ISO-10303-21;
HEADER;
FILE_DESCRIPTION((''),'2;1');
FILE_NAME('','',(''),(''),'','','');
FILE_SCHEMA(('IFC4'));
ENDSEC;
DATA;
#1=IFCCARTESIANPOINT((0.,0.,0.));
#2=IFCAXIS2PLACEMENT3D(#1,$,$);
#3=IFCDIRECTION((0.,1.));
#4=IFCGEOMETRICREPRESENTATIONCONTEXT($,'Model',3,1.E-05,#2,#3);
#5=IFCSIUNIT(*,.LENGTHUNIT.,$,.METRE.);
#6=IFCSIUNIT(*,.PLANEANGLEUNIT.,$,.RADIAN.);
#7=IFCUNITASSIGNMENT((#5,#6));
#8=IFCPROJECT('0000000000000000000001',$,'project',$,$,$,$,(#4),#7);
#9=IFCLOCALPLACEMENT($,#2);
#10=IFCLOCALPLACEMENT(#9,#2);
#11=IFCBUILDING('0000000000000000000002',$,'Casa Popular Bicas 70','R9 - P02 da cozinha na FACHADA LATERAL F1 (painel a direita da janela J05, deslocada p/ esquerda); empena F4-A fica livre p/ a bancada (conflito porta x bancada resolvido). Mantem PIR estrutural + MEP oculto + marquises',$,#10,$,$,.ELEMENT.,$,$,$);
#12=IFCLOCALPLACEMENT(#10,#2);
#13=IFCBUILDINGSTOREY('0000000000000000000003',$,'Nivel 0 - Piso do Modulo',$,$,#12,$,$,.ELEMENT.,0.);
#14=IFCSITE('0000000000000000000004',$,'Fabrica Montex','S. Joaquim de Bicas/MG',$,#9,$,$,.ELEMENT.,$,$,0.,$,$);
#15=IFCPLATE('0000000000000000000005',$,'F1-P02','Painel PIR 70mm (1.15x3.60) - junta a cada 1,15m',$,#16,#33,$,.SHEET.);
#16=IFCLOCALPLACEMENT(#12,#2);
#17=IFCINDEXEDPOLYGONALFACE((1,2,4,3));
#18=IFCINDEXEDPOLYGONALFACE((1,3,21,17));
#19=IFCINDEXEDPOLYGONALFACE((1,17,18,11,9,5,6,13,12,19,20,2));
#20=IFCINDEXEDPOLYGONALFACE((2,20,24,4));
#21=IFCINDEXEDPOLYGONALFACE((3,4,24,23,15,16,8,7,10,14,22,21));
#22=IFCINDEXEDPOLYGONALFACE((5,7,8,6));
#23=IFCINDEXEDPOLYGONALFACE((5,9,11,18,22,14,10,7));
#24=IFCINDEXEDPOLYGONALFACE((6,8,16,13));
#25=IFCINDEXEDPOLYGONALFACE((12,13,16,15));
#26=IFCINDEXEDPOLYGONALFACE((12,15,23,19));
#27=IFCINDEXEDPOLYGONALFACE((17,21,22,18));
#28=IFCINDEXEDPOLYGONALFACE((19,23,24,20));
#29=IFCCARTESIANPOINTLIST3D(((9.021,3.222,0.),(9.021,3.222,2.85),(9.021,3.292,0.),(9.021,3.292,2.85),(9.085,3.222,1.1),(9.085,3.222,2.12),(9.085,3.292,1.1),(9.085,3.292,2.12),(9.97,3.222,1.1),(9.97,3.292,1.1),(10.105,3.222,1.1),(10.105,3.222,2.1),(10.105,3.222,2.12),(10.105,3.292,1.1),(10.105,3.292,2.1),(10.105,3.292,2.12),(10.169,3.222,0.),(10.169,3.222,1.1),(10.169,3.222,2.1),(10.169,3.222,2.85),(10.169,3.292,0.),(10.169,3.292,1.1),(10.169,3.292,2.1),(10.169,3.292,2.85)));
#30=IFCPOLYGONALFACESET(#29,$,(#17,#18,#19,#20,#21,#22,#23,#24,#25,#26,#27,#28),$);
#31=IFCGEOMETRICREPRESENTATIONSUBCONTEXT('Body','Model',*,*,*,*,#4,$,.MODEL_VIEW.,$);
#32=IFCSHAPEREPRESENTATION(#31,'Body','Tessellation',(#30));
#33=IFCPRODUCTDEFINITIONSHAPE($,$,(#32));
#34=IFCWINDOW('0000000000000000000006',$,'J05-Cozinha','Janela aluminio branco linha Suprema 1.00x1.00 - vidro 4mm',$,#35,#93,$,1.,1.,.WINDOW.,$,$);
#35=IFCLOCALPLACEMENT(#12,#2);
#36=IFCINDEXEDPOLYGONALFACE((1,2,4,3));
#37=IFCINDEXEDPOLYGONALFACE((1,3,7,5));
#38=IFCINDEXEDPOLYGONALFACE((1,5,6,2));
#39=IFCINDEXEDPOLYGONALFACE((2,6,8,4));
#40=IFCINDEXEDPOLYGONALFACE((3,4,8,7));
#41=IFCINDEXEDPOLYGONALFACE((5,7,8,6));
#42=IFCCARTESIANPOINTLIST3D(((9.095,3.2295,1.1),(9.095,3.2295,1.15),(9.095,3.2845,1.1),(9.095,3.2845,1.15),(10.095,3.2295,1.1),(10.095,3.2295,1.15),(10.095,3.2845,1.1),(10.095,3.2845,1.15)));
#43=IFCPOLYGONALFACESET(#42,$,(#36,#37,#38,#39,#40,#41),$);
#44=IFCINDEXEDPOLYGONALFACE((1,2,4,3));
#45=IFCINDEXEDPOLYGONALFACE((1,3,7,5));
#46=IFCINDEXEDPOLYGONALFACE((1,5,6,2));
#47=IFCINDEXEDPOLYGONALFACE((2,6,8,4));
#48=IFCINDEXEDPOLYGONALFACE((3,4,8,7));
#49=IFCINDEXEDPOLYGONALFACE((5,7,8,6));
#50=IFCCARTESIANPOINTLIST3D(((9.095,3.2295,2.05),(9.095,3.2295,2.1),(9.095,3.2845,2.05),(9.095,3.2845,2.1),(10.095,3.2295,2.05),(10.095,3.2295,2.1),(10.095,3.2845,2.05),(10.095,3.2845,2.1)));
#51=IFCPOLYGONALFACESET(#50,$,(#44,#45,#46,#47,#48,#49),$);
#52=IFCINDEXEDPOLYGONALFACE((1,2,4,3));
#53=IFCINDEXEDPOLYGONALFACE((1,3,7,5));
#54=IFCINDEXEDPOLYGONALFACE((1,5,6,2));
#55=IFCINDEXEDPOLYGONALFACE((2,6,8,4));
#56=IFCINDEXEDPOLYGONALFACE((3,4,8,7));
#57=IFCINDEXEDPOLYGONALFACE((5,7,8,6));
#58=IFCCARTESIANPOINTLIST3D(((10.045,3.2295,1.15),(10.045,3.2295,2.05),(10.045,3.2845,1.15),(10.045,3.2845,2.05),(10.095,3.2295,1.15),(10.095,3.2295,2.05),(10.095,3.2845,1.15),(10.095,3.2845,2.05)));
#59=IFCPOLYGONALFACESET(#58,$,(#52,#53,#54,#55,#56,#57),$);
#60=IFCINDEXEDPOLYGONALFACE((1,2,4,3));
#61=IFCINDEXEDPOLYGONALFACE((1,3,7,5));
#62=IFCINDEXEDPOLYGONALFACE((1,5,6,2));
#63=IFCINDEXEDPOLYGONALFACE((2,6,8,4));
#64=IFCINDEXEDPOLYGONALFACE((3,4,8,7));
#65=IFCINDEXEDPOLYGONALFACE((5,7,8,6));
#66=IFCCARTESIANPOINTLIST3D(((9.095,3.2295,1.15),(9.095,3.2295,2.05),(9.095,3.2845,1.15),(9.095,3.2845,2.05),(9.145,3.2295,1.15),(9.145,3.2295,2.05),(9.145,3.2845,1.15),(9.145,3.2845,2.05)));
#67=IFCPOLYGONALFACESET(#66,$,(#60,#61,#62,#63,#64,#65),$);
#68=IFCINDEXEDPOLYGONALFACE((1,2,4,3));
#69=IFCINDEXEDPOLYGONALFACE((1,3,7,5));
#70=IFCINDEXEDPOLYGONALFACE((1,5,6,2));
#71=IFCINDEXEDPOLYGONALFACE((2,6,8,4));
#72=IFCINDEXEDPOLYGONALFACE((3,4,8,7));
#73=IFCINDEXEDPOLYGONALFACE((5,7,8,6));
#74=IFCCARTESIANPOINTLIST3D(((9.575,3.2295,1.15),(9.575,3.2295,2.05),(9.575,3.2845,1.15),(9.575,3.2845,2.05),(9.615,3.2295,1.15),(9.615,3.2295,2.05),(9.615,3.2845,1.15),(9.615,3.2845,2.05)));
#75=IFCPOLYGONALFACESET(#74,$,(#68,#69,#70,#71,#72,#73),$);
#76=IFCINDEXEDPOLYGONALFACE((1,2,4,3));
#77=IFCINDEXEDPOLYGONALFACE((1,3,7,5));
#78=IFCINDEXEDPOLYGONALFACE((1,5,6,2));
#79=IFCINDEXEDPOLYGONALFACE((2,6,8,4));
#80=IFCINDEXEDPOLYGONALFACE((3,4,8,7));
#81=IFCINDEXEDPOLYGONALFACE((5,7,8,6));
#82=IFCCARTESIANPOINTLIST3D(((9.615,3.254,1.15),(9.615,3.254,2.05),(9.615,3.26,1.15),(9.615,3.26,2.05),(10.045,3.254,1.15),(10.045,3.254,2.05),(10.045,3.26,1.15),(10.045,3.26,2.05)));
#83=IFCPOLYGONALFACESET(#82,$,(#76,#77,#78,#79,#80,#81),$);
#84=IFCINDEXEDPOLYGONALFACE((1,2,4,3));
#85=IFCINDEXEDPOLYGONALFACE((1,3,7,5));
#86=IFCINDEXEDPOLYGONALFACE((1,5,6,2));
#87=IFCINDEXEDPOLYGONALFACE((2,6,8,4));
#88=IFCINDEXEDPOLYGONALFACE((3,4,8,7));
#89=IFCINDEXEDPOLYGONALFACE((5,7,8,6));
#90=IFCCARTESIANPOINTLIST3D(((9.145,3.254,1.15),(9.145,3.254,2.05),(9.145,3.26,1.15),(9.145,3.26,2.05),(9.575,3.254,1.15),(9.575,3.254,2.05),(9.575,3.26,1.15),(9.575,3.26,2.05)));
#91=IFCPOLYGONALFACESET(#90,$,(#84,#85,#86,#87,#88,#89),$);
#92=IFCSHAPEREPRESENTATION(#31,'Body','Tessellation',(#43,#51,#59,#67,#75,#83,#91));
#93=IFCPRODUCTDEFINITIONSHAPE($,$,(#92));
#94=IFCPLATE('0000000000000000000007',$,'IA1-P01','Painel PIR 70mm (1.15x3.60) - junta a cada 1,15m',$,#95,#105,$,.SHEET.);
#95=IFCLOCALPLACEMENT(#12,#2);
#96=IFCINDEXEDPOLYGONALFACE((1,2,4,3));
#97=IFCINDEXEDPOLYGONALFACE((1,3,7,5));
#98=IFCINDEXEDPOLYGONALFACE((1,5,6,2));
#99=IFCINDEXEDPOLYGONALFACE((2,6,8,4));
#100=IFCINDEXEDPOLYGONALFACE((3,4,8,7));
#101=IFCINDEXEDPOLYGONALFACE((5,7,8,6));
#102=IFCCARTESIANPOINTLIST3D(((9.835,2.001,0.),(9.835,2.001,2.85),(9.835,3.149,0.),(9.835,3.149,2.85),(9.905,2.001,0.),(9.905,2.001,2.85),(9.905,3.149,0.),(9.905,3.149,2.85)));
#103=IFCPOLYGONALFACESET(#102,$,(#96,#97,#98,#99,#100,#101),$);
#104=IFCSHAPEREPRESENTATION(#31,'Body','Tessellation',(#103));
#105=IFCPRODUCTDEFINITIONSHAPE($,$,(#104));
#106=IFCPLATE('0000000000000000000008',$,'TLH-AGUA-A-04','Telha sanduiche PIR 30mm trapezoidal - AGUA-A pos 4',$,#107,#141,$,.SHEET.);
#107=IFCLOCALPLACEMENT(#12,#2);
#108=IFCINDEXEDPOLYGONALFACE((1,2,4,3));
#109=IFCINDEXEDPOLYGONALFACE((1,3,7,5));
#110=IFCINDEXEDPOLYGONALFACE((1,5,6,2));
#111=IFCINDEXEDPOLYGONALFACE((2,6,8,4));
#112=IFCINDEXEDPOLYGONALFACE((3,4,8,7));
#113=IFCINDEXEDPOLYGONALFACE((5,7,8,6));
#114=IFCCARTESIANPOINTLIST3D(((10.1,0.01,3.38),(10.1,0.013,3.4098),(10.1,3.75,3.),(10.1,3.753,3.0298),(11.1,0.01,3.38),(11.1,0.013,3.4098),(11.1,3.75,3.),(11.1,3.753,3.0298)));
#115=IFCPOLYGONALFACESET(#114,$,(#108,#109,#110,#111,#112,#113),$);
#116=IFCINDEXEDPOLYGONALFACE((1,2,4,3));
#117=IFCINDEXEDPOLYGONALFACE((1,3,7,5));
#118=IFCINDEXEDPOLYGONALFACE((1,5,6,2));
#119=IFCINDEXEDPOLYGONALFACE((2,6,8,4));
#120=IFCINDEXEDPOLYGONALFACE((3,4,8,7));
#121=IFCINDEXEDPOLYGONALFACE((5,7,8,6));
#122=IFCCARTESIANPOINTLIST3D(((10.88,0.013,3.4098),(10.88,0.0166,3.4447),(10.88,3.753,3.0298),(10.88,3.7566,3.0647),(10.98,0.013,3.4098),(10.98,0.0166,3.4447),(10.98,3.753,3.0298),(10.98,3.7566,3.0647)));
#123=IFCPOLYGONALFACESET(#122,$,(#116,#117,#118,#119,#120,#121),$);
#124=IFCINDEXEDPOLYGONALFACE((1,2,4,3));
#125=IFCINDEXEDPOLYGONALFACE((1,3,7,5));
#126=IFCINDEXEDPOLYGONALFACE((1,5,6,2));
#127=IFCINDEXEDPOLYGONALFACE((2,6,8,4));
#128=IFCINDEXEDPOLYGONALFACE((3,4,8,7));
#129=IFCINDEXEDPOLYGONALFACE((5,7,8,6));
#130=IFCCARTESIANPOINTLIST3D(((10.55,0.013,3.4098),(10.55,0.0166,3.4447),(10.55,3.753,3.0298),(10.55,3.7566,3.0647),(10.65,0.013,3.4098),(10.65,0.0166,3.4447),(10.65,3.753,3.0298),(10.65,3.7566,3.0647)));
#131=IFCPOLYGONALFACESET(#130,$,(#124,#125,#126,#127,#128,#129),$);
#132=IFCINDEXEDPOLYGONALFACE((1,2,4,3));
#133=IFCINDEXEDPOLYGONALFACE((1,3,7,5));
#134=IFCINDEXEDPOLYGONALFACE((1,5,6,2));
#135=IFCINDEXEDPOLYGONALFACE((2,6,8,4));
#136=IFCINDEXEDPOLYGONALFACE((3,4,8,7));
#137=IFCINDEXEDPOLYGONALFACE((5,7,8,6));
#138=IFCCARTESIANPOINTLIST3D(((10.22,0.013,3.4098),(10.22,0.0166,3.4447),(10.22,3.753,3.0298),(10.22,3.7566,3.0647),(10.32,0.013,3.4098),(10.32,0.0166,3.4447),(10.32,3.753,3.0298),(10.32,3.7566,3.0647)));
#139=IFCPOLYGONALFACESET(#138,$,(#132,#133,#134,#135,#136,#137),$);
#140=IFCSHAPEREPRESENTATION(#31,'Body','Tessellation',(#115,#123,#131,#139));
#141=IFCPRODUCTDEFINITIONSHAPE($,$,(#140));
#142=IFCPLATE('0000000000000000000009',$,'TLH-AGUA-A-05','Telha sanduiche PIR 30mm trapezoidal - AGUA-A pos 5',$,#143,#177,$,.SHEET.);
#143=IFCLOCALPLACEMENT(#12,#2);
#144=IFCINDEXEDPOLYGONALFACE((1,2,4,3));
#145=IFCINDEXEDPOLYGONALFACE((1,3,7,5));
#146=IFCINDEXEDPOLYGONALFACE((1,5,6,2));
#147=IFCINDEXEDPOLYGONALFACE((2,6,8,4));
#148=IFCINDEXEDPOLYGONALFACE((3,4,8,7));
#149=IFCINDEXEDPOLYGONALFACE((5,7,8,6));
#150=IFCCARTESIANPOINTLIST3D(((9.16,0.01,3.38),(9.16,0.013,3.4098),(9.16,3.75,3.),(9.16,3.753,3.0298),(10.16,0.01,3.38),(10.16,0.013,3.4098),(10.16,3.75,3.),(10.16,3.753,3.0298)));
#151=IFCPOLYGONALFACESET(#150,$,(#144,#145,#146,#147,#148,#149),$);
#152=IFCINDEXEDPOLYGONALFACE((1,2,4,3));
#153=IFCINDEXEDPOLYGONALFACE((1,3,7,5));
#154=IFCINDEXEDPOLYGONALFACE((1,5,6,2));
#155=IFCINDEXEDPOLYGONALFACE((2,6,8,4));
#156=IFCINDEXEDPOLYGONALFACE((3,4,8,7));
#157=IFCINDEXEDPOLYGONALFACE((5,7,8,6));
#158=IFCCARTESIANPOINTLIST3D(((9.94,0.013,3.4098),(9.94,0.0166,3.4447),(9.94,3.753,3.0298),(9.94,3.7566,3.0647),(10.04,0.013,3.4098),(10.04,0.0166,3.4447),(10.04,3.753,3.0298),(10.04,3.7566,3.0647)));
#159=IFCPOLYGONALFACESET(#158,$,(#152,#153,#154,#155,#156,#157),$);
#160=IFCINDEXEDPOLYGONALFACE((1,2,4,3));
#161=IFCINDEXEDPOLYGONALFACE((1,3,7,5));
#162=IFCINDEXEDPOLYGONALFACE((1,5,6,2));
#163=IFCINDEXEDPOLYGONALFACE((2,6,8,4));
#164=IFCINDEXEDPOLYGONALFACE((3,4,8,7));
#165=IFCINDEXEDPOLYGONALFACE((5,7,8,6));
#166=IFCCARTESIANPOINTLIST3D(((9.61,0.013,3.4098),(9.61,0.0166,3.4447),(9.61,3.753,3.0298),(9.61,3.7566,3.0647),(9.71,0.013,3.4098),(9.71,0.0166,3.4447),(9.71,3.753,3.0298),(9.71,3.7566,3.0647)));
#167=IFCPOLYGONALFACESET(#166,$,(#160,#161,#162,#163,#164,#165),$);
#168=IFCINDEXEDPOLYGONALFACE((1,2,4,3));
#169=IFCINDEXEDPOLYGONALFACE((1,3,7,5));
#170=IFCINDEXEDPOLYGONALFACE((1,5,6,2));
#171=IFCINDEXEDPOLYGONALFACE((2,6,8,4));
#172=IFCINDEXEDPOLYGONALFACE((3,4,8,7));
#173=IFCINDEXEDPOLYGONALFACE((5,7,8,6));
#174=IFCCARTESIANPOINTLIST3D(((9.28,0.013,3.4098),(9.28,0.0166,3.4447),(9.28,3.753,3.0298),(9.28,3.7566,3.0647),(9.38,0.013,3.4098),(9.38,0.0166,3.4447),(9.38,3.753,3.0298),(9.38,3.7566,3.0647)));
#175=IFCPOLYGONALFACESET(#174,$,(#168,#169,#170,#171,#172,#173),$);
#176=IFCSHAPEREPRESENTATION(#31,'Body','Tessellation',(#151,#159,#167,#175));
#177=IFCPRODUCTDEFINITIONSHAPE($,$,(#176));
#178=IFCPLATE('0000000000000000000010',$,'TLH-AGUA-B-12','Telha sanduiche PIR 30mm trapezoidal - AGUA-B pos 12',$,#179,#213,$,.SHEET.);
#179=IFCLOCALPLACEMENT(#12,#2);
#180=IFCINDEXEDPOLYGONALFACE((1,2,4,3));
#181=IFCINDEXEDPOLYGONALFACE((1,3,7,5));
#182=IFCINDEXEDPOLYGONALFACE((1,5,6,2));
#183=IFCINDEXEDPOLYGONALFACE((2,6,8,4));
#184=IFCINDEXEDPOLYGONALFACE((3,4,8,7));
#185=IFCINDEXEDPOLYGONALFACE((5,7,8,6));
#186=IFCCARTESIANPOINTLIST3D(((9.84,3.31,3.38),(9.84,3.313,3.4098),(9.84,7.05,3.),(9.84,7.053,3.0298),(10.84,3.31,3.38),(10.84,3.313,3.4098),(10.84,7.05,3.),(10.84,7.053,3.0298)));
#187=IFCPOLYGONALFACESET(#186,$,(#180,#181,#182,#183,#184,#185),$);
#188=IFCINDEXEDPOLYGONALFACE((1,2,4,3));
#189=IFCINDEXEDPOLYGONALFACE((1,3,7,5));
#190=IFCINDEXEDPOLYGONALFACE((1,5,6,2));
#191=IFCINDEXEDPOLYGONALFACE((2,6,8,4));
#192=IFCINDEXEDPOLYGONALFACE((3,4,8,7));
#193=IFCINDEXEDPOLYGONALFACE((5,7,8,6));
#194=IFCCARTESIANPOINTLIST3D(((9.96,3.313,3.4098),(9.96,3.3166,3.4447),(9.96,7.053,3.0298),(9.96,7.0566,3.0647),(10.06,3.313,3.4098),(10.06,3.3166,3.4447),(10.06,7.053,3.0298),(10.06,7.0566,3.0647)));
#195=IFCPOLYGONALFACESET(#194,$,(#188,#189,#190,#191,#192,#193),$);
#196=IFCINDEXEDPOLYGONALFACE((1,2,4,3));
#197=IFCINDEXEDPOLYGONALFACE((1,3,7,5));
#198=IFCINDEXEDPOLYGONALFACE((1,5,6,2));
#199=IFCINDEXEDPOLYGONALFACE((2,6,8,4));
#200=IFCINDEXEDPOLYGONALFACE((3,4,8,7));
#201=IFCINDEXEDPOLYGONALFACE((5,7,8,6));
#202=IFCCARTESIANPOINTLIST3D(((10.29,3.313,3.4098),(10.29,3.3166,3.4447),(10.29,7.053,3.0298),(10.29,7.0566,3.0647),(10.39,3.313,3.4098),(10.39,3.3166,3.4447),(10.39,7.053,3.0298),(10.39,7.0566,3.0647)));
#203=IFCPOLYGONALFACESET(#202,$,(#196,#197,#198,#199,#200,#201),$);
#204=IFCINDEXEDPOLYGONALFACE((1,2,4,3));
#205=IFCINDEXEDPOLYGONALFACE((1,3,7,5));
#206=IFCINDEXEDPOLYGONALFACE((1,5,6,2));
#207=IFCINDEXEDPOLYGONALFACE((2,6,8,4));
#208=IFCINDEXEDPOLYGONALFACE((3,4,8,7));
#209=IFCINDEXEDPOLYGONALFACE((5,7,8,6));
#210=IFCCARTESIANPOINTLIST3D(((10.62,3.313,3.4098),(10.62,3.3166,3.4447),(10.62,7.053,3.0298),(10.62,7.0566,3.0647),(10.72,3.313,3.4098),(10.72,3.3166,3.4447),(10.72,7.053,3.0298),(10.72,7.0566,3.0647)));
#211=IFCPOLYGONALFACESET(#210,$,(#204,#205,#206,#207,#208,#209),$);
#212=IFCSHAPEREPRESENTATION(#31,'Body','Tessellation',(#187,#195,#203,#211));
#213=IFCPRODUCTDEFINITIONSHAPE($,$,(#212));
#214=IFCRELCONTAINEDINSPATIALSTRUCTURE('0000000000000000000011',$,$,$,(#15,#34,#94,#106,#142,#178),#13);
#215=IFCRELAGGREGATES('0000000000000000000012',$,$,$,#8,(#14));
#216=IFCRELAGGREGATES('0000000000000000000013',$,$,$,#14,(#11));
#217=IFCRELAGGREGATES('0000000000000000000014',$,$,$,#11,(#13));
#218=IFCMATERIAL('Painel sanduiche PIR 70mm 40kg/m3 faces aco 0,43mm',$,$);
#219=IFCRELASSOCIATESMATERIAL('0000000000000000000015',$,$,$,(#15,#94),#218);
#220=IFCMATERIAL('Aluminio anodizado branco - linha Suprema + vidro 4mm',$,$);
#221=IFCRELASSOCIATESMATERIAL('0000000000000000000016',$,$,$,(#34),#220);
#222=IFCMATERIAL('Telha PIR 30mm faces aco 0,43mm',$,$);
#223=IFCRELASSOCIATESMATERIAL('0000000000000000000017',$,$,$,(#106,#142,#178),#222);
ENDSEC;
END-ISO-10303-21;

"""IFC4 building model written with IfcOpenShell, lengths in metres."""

from ifc_helpers import new_model, si_unit, direction, frame, frame_2d, origin, origin_2d, place, context, subcontext, project, spatial, rectangle, extrude, material, element, fill, save


model = new_model("IFC4")

# Units and contexts
model_context = context("Model", 3, precision=1e-05, world=origin(), true_north=direction((0.0, 1.0)))
body_context = subcontext(model_context, "Body", "Model", "MODEL_VIEW")
ifc_project = project(units=[si_unit("LENGTHUNIT", "METRE"), si_unit("PLANEANGLEUNIT", "RADIAN")], contexts=[model_context])

# Site, building, storey
site_placement = place(None, origin())
site = spatial("IfcSite", under=ifc_project, at=site_placement, Name="Fabrica Montex", Description="S. Joaquim de Bicas/MG", CompositionType="ELEMENT", RefElevation=0.0)
building_placement = place(site_placement, origin())
building = spatial("IfcBuilding", under=site, at=building_placement, Name="Casa Popular Bicas 70", Description="R9 - P02 da cozinha na FACHADA LATERAL F1 (painel a direita da janela J05, deslocada p/ esquerda); empena F4-A fica livre p/ a bancada (conflito porta x bancada resolvido). Mantem PIR estrutural + MEP oculto + marquises", CompositionType="ELEMENT")
storey_placement = place(building_placement, origin())
storey = spatial("IfcBuildingStorey", under=building, at=storey_placement, Name="Nivel 0 - Piso do Modulo", CompositionType="ELEMENT", Elevation=0.0)

# Plate, openings, window
ifc_material_1 = material(Name="Painel sanduiche PIR 70mm 40kg/m3 faces aco 0,43mm")
plate_1_placement = place(None, frame((10.169, 3.257, 0.0), z_axis=(0.0, 0.0, 1.0), x_axis=(-1.0, 0.0, 0.0)))
plate_1 = element("IfcPlate", 1, at=plate_1_placement, inside=storey, material=ifc_material_1, Name="F1-P02", Description="Painel PIR 70mm (1.15x3.60) - junta a cada 1,15m", PredefinedType="SHEET", context=body_context, shape_type="SweptSolid", body=[
    extrude(rectangle(XDim=1.148, YDim=0.07, at=frame_2d((0.574, 0.0))), origin(), (0.0, 0.0, 1.0), 2.85),
])
opening_1_placement = place(None, frame((10.095, 3.257, 1.1), z_axis=(0.0, 0.0, 1.0), x_axis=(-1.0, 0.0, 0.0)))
opening_1 = element("IfcOpeningElement", 2, at=opening_1_placement, cuts=plate_1, PredefinedType="OPENING", context=body_context, shape_type="SweptSolid", body=[
    extrude(rectangle(XDim=1.02, YDim=0.3, at=frame_2d((0.5, 0.0))), origin(), (0.0, 0.0, 1.0), 1.02),
])
opening_2_placement = place(None, frame((10.07, 3.257, 1.1), z_axis=(0.0, 0.0, 1.0), x_axis=(-1.0, 0.0, 0.0)))
element("IfcOpeningElement", 3, at=opening_2_placement, cuts=plate_1, PredefinedType="OPENING", context=body_context, shape_type="SweptSolid", body=[
    extrude(rectangle(XDim=0.2, YDim=0.1, at=origin_2d()), origin(), (0.0, 0.0, 1.0), 1.0),
])
ifc_material_2 = material(Name="Aluminio anodizado branco - linha Suprema + vidro 4mm")
window_placement = place(None, frame((10.095, 3.257, 1.1), z_axis=(0.0, 0.0, 1.0), x_axis=(-1.0, 0.0, 0.0)))
window = element("IfcWindow", 4, at=window_placement, inside=storey, material=ifc_material_2, Name="J05-Cozinha", Description="Janela aluminio branco linha Suprema 1.00x1.00 - vidro 4mm", OverallHeight=1.0, OverallWidth=1.0, PredefinedType="WINDOW", context=body_context, shape_type="SweptSolid", body=[
    extrude(rectangle(XDim=1.0, YDim=0.055, at=frame_2d((0.5, 0.0))), origin(), (0.0, 0.0, 1.0), 0.05),
    extrude(rectangle(XDim=1.0, YDim=0.055, at=frame_2d((0.5, 0.0))), frame((0.0, 0.0, 0.95)), (0.0, 0.0, 1.0), 0.05),
    extrude(rectangle(XDim=0.05, YDim=0.055, at=frame_2d((0.025, 0.0))), frame((0.0, 0.0, 0.05)), (0.0, 0.0, 1.0), 0.9),
    extrude(rectangle(XDim=0.05, YDim=0.055, at=frame_2d((0.975, 0.0))), frame((0.0, 0.0, 0.05)), (0.0, 0.0, 1.0), 0.9),
    extrude(rectangle(XDim=0.04, YDim=0.055, at=frame_2d((0.5, 0.0))), frame((0.0, 0.0, 0.05)), (0.0, 0.0, 1.0), 0.9),
    extrude(rectangle(XDim=0.43, YDim=0.006, at=frame_2d((0.265, 0.0))), frame((0.0, 0.0, 0.05)), (0.0, 0.0, 1.0), 0.9),
    extrude(rectangle(XDim=0.43, YDim=0.006, at=frame_2d((0.735, 0.0))), frame((0.0, 0.0, 0.05)), (0.0, 0.0, 1.0), 0.9),
])
fill(opening_1, window)

# Plates
plate_2_placement = place(None, frame((9.87, 3.149, 0.0), z_axis=(0.0, 0.0, 1.0), x_axis=(0.0, -1.0, 0.0)))
element("IfcPlate", 5, at=plate_2_placement, inside=storey, material=ifc_material_1, Name="IA1-P01", Description="Painel PIR 70mm (1.15x3.60) - junta a cada 1,15m", PredefinedType="SHEET", context=body_context, shape_type="SweptSolid", body=[
    extrude(rectangle(XDim=1.148, YDim=0.07, at=frame_2d((0.574, 0.0))), origin(), (0.0, 0.0, 1.0), 2.85),
])
ifc_material_3 = material(Name="Telha PIR 30mm faces aco 0,43mm")
for number, where, z_axis, x_axis, name, description in (
    (6, (11.1, 3.75, 3.0), (0.0, 0.101084, 0.994878), (-1.0, 0.0, 0.0), "TLH-AGUA-A-04", "Telha sanduiche PIR 30mm trapezoidal - AGUA-A pos 4"),
    (7, (10.16, 3.75, 3.0), (0.0, 0.101084, 0.994878), (-1.0, 0.0, 0.0), "TLH-AGUA-A-05", "Telha sanduiche PIR 30mm trapezoidal - AGUA-A pos 5"),
):
    element("IfcPlate", number, at=place(None, frame(where, z_axis=z_axis, x_axis=x_axis)), inside=storey, material=ifc_material_3, Name=name, Description=description, PredefinedType="SHEET", context=body_context, shape_type="SweptSolid", body=[
        extrude(rectangle(XDim=1.0, YDim=3.7593, at=frame_2d((0.5, 1.8796))), origin(), (0.0, 0.0, 1.0), 0.03),
        extrude(rectangle(XDim=0.1, YDim=3.7593, at=frame_2d((0.17, 1.8796))), frame((0.0, 0.0, 0.03)), (0.0, 0.0, 1.0), 0.035),
        extrude(rectangle(XDim=0.1, YDim=3.7593, at=frame_2d((0.5, 1.8796))), frame((0.0, 0.0, 0.03)), (0.0, 0.0, 1.0), 0.035),
        extrude(rectangle(XDim=0.1, YDim=3.7593, at=frame_2d((0.83, 1.8796))), frame((0.0, 0.0, 0.03)), (0.0, 0.0, 1.0), 0.035),
    ])
for number, where, z_axis, x_axis, name in (
    (8, (9.84, 3.31, 3.38), (0.0, 0.101084, 0.994878), (1.0, 0.0, 0.0), "TLH-AGUA-B-12"),
):
    element("IfcPlate", number, at=place(storey_placement, frame(where, z_axis=z_axis, x_axis=x_axis)), inside=storey, material=ifc_material_3, Name=name, Description="Telha sanduiche PIR 30mm trapezoidal - AGUA-B pos 12", PredefinedType="SHEET", context=body_context, shape_type="SweptSolid", body=[
        extrude(rectangle(XDim=1.0, YDim=3.7593, at=frame_2d((0.5, 1.8796))), origin(), (0.0, 0.0, 1.0), 0.03),
        extrude(rectangle(XDim=0.1, YDim=3.7593, at=frame_2d((0.17, 1.8796))), frame((0.0, 0.0, 0.03)), (0.0, 0.0, 1.0), 0.035),
        extrude(rectangle(XDim=0.1, YDim=3.7593, at=frame_2d((0.5, 1.8796))), frame((0.0, 0.0, 0.03)), (0.0, 0.0, 1.0), 0.035),
        extrude(rectangle(XDim=0.1, YDim=3.7593, at=frame_2d((0.83, 1.8796))), frame((0.0, 0.0, 0.03)), (0.0, 0.0, 1.0), 0.035),
    ])

save(model, "model.ifc")
